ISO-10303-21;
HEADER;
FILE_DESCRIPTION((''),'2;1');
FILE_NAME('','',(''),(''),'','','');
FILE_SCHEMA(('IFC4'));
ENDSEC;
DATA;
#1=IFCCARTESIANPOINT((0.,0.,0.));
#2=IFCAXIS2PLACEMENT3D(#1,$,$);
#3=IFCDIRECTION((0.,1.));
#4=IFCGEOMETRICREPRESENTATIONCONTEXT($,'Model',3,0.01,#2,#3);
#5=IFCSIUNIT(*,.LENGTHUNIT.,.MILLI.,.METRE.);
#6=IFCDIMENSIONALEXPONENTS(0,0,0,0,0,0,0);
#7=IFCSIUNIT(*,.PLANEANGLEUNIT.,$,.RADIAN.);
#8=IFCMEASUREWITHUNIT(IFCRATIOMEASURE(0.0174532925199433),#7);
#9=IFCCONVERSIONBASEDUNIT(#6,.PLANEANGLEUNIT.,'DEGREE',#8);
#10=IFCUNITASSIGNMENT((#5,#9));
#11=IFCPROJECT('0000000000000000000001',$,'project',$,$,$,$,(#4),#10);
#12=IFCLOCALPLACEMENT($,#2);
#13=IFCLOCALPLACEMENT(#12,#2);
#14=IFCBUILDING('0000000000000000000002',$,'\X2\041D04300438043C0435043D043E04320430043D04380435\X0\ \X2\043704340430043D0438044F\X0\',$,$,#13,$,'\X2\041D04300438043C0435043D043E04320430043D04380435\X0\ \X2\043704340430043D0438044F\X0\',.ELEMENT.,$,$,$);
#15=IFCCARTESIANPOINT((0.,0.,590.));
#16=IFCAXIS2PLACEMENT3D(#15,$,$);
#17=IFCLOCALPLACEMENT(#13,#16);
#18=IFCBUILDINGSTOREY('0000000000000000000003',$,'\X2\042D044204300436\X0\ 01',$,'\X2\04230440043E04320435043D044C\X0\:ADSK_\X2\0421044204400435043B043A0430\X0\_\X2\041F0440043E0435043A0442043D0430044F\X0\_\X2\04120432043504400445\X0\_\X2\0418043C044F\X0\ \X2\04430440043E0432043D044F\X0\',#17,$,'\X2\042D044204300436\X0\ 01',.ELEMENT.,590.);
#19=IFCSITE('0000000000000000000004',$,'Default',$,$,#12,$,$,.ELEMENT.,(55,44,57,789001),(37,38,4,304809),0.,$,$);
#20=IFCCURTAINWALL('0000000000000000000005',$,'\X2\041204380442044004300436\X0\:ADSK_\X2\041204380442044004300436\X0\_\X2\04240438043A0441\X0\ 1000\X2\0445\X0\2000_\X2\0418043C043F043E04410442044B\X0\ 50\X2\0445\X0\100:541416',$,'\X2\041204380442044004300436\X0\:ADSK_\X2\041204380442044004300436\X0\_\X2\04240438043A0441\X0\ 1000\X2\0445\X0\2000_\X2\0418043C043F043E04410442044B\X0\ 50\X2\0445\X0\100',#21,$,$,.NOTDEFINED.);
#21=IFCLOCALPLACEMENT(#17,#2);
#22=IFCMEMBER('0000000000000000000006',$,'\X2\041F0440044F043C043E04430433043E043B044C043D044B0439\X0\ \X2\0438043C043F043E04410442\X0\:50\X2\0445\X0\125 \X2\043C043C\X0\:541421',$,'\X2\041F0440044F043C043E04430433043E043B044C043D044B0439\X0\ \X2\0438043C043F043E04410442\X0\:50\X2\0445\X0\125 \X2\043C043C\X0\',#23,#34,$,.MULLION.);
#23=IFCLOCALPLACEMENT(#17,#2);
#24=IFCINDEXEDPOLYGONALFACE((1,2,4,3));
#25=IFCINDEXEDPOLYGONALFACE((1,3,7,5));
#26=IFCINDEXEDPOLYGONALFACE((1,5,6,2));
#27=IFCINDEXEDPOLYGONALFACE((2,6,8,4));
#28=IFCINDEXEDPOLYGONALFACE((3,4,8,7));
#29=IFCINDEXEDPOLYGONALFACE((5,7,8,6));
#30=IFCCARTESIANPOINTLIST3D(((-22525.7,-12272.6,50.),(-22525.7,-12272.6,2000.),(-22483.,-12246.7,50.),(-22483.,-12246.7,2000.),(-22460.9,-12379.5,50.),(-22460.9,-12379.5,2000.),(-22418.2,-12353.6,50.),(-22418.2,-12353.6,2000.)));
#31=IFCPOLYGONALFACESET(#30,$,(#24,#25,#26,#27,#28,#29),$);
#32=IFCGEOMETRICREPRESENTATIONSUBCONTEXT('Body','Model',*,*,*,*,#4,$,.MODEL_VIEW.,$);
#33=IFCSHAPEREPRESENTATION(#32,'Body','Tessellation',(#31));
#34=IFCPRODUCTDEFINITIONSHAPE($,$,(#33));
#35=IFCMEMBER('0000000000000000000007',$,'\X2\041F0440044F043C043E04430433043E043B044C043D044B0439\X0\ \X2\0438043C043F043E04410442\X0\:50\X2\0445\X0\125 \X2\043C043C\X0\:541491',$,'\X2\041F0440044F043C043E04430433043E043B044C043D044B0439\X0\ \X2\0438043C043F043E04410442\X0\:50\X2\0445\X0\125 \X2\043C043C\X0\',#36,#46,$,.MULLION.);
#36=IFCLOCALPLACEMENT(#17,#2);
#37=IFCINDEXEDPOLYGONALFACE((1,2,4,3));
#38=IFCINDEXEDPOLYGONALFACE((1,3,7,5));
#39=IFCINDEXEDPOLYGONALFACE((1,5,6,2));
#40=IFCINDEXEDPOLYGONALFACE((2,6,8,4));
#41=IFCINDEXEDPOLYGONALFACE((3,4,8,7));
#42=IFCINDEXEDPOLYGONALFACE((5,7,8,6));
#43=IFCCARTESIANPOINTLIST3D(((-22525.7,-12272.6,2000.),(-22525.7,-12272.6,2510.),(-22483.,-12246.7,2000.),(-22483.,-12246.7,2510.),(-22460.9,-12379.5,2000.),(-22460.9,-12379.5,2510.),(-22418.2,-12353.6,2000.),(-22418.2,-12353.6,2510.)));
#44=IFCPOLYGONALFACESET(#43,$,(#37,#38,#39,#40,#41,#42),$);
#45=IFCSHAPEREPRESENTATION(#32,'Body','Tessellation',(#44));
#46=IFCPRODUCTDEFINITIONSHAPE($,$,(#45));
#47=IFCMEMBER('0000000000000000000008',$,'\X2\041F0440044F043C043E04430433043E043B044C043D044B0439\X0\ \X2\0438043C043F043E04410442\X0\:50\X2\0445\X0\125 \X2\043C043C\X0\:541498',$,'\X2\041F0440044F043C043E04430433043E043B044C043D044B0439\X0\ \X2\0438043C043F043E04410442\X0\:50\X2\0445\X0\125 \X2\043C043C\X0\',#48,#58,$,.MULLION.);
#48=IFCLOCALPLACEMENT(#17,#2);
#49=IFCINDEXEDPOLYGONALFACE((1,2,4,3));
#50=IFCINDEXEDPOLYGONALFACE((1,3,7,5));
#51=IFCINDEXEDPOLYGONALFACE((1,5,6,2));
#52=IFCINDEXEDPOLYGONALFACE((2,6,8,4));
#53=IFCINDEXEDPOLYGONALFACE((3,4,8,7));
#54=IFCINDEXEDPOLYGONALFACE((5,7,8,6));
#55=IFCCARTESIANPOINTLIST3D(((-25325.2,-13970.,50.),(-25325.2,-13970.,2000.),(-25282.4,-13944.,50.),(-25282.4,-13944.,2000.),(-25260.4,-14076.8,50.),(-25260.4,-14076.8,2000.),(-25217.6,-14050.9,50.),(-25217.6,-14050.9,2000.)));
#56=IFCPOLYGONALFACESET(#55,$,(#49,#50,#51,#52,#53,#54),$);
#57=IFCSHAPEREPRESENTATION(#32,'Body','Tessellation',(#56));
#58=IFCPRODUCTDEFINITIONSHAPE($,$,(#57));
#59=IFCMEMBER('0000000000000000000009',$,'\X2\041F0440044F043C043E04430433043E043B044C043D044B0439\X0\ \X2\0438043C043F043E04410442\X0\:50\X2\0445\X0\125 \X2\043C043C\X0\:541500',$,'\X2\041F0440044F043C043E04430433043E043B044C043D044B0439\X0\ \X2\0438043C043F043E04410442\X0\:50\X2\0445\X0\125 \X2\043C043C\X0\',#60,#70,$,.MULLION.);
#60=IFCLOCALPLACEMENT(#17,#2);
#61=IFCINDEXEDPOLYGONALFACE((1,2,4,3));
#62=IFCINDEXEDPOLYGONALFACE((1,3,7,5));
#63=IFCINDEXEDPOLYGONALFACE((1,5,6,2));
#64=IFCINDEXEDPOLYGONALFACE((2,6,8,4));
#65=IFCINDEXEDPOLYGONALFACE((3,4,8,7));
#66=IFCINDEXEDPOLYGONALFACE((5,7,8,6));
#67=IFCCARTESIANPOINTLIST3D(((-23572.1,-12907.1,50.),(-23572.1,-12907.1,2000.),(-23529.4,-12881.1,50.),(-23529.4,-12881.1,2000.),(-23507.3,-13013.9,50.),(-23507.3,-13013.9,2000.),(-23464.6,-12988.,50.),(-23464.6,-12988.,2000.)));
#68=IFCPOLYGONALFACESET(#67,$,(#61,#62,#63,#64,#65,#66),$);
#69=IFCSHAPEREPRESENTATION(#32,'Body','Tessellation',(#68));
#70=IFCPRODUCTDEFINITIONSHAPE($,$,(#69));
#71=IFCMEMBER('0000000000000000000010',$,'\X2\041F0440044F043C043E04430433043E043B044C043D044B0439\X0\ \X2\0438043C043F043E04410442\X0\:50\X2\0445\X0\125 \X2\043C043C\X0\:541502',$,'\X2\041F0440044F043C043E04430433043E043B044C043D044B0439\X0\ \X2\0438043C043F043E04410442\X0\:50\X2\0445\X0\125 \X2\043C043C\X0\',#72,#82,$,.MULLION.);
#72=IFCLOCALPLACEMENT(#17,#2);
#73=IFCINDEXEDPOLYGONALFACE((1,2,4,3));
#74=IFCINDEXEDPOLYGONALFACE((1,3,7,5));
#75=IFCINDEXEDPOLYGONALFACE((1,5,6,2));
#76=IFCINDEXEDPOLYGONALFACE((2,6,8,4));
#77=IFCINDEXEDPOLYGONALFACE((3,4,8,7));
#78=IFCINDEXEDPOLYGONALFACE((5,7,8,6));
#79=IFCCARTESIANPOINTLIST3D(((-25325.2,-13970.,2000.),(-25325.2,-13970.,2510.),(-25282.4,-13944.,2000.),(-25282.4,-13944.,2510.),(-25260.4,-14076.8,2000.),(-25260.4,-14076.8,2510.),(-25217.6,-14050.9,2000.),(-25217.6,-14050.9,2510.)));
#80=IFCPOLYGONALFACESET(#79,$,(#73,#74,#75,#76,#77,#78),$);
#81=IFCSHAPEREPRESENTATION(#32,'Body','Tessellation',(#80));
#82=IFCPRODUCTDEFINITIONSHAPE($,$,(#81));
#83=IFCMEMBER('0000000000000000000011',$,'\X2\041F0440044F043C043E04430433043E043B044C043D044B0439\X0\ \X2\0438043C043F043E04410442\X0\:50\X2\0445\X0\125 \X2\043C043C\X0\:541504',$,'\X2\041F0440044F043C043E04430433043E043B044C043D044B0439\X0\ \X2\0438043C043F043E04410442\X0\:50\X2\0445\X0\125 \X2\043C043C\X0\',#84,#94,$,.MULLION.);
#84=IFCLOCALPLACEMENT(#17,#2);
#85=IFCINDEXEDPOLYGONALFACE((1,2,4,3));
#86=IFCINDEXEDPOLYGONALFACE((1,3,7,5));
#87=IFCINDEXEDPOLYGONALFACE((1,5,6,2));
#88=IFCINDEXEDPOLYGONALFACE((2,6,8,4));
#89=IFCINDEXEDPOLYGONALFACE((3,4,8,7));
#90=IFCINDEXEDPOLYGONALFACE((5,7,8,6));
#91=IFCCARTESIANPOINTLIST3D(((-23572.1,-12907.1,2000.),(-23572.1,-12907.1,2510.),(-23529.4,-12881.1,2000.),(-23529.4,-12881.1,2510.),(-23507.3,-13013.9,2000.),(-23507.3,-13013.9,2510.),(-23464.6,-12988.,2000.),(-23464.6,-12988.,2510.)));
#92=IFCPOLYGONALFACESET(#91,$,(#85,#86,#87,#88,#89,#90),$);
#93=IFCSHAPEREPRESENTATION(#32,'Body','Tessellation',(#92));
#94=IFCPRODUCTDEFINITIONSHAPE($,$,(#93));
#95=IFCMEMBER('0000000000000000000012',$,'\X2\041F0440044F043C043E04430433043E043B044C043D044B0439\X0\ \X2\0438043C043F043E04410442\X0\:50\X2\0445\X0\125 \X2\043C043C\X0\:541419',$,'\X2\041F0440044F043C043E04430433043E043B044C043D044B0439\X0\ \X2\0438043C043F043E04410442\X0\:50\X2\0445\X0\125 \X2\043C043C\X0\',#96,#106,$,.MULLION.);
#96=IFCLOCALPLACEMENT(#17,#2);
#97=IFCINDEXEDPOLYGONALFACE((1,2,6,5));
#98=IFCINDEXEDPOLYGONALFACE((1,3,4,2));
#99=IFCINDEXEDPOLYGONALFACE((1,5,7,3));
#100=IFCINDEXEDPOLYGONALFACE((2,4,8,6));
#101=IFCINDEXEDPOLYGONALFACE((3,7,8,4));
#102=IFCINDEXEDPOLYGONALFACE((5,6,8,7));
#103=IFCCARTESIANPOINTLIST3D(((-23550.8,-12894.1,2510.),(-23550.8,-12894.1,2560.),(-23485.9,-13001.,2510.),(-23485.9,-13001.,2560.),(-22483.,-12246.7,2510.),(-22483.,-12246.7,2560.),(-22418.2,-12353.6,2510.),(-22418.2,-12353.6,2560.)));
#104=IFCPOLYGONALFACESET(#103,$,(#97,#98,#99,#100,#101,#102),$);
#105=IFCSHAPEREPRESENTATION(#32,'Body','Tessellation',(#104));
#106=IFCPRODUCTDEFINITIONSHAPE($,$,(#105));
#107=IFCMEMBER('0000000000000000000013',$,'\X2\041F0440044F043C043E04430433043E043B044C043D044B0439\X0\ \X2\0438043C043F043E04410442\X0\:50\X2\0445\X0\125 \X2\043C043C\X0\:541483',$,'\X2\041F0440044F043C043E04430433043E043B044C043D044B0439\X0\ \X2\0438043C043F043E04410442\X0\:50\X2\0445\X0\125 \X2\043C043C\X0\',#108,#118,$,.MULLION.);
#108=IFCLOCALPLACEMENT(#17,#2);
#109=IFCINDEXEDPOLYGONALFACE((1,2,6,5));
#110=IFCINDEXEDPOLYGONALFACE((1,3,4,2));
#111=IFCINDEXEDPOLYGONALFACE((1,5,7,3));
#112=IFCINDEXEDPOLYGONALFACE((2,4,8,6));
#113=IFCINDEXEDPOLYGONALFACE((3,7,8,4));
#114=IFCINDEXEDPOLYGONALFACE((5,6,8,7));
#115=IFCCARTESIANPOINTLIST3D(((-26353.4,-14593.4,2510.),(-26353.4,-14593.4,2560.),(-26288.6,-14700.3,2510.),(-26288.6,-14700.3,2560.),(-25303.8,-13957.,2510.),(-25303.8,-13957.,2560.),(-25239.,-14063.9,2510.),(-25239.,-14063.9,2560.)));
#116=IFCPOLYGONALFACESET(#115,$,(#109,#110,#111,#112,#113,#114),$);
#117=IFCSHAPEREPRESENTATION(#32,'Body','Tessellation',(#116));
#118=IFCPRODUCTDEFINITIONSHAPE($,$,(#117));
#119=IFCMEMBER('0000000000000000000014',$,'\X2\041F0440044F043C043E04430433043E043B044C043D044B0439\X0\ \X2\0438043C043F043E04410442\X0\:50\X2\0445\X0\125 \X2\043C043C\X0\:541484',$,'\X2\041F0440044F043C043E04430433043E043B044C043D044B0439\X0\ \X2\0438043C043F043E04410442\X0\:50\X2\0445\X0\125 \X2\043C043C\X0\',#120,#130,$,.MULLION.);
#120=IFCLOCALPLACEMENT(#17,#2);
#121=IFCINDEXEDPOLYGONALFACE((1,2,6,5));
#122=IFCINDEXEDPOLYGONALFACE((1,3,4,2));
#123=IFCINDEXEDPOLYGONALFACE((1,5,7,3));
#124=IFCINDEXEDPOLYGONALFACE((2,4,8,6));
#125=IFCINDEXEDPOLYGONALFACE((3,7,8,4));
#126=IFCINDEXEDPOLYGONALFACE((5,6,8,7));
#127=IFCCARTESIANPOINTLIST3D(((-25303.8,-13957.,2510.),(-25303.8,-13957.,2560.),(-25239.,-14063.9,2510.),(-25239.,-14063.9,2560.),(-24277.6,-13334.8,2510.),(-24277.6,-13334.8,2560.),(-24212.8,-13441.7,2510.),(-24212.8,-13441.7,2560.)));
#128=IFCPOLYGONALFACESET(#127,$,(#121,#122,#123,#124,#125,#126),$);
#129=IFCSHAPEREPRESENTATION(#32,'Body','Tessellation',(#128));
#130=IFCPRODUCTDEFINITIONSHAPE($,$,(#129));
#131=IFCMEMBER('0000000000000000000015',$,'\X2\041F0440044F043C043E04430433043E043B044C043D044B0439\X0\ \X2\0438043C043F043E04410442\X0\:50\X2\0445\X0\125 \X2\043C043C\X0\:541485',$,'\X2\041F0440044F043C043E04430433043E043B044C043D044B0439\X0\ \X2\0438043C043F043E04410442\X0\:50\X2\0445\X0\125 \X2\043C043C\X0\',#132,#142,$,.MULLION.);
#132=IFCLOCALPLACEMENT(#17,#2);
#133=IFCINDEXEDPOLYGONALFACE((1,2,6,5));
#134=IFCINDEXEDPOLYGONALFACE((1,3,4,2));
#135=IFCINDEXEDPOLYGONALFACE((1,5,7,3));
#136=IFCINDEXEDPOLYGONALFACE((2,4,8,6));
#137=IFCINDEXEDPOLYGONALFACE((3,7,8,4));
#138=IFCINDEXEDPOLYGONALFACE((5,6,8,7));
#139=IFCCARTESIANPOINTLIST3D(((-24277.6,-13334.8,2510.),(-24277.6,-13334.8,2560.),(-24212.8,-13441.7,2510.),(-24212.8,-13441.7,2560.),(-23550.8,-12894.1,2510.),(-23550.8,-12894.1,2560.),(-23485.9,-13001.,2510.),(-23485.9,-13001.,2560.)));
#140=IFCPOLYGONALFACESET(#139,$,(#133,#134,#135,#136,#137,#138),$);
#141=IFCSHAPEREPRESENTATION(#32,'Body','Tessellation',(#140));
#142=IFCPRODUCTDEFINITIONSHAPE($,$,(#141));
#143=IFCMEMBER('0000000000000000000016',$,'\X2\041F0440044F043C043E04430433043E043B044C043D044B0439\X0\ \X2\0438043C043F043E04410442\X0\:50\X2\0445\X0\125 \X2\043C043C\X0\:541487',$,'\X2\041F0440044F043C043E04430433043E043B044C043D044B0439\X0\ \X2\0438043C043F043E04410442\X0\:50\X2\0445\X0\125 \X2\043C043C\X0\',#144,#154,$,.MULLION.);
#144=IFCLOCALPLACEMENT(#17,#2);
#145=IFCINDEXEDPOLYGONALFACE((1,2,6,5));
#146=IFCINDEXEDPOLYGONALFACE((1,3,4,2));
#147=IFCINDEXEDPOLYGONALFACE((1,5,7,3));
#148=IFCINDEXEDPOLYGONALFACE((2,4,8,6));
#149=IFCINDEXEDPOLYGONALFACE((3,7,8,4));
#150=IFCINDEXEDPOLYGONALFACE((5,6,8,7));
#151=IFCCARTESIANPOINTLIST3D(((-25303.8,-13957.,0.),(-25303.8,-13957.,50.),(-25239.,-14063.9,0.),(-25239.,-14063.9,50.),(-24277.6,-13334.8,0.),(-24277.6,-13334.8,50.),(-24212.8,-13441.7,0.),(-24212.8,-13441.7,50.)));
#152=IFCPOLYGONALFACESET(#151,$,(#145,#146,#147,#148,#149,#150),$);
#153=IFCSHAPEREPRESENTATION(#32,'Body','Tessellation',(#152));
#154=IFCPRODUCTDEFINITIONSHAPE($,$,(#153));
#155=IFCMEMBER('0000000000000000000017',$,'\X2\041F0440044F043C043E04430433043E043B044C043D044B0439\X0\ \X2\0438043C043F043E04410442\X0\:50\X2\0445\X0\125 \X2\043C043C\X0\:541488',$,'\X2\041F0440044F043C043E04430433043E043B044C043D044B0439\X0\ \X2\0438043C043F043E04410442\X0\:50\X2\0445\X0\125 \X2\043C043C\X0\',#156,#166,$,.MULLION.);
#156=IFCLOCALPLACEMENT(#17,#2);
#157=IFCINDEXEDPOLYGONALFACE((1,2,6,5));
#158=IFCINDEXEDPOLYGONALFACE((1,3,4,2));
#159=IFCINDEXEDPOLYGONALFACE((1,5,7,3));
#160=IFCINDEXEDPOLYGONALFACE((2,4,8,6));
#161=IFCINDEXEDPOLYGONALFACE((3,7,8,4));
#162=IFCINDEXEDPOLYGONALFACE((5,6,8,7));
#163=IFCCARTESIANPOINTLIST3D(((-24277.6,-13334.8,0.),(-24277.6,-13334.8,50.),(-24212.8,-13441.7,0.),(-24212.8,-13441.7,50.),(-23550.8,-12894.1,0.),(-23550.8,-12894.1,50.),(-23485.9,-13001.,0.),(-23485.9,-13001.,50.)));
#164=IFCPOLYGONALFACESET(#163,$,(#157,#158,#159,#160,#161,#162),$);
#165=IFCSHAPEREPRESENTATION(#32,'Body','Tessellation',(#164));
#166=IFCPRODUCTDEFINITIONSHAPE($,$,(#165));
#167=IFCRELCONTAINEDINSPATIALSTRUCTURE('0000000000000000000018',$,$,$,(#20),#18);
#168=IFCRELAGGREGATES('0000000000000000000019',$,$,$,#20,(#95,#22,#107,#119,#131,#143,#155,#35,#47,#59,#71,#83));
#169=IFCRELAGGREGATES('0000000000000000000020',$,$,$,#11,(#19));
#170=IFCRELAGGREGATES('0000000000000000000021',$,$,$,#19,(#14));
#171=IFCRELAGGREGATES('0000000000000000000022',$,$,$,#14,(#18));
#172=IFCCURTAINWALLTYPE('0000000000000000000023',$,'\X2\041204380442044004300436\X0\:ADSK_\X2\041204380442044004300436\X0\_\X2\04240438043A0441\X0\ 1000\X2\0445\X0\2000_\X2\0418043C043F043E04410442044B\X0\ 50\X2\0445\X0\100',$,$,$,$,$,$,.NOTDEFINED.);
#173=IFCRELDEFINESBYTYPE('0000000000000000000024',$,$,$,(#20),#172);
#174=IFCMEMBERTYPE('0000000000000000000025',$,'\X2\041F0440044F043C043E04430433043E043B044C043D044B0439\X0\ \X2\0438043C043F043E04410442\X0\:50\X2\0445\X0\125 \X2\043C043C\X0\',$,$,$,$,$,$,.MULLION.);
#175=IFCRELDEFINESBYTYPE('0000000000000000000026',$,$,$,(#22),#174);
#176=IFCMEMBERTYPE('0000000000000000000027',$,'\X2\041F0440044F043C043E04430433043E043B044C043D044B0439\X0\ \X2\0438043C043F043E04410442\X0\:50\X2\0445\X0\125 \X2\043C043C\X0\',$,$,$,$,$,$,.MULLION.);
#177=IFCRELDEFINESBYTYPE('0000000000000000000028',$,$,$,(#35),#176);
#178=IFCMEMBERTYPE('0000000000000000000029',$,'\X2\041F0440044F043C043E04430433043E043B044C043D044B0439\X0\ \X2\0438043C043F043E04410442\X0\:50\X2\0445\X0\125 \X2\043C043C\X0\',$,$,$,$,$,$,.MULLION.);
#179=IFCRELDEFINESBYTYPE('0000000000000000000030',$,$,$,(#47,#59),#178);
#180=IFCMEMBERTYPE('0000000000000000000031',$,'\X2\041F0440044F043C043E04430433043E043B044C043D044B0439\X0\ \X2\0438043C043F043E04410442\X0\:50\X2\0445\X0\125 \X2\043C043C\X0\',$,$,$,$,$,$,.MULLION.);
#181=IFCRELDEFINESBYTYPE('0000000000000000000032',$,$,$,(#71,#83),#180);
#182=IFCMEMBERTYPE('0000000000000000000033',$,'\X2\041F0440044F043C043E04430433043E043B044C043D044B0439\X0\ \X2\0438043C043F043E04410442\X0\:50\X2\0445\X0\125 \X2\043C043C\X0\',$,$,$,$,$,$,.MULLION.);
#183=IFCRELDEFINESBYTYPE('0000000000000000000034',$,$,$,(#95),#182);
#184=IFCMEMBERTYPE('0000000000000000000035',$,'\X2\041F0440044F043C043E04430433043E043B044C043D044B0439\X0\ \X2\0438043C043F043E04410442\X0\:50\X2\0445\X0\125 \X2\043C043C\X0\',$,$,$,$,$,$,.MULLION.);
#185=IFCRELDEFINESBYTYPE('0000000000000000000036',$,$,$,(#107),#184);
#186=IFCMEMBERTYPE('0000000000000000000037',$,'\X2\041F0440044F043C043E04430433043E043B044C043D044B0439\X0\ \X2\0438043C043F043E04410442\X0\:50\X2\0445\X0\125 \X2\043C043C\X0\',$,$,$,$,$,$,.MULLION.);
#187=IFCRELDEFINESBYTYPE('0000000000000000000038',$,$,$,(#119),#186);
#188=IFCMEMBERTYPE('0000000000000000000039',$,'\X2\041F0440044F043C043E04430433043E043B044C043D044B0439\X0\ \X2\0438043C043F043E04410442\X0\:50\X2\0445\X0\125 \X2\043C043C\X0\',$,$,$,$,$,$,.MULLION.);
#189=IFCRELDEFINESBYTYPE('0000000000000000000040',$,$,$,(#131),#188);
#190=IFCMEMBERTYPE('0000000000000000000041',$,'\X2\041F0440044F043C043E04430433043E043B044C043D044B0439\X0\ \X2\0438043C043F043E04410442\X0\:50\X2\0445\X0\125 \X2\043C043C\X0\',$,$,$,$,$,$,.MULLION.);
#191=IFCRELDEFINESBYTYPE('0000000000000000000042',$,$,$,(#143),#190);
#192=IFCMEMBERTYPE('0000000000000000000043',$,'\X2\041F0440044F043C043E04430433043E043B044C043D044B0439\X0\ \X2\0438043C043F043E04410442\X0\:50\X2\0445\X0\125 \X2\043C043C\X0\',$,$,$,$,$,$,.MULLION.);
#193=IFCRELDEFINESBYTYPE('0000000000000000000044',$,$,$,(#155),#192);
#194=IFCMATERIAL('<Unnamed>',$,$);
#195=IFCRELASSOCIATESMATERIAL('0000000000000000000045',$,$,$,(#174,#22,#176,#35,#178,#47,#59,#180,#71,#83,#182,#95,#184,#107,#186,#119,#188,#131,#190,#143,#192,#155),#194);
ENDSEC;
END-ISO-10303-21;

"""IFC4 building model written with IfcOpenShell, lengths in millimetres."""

from ifc_helpers import new_model, entity, si_unit, converted_unit, direction, frame, origin, place, context, subcontext, project, spatial, indexed_curve, outline, extrude, source, transform, mapped, material, type_object, type_shapes, element, aggregate, save


model = new_model("IFC4")

# Units and contexts
model_context = context("Model", 3, precision=0.01, world=origin(), true_north=direction((0.0, 1.0)))
body_context = subcontext(model_context, "Body", "Model", "MODEL_VIEW")
ifc_project = project(units=[si_unit("LENGTHUNIT", "METRE", prefix="MILLI"), converted_unit("PLANEANGLEUNIT", "DEGREE", entity("IfcRatioMeasure", 0.0174532925199433), si_unit("PLANEANGLEUNIT", "RADIAN"), dimensions=[0, 0, 0, 0, 0, 0, 0])], contexts=[model_context])

# Site, building, storey
site_placement = place(None, origin())
site = spatial("IfcSite", under=ifc_project, at=site_placement, Name="Default", CompositionType="ELEMENT", RefLatitude=(55, 44, 57, 789001), RefLongitude=(37, 38, 4, 304809), RefElevation=0.0)
building_placement = place(site_placement, origin())
building = spatial("IfcBuilding", under=site, at=building_placement, Name="Наименование здания", LongName="Наименование здания", CompositionType="ELEMENT")
storey_placement = place(building_placement, frame((0.0, 0.0, 590.0)))
storey = spatial("IfcBuildingStorey", under=building, at=storey_placement, Name="Этаж 01", ObjectType="Уровень:ADSK_Стрелка_Проектная_Вверх_Имя уровня", LongName="Этаж 01", CompositionType="ELEMENT", Elevation=590.0)

# Curtain wall, members
curtain_wall_type = type_object("IfcCurtainWallType", Name="Витраж:ADSK_Витраж_Фикс 1000х2000_Импосты 50х100", PredefinedType="NOTDEFINED")
curtain_wall_placement = place(storey_placement, frame((0.0, 0.0, -590.0)))
curtain_wall = element("IfcCurtainWall", 1, at=curtain_wall_placement, inside=storey, type_object=curtain_wall_type, Name="Витраж:ADSK_Витраж_Фикс 1000х2000_Импосты 50х100:541416", ObjectType="Витраж:ADSK_Витраж_Фикс 1000х2000_Импосты 50х100", PredefinedType="NOTDEFINED")
ifc_material_1 = material(Name="<Unnamed>")
member_type_1 = type_object("IfcMemberType", Name="Прямоугольный импост:50х125 мм", PredefinedType="MULLION", material=ifc_material_1)
shared_shape_1 = source(origin(), body_context, "Body", "SweptSolid", [
    extrude(outline(indexed_curve([(-62.5, -25.0), (62.5, -25.0), (62.5, 25.0), (-62.5, 25.0), (-62.5, -25.0)], self_intersect=False)), frame((-25.0, 0.0, -1950.0), z_axis=(0.0, 0.0, 1.0), x_axis=(0.0, -1.0, 0.0)), (0.0, 0.0, 1.0), 1950.0),
])
type_shapes(member_type_1, [shared_shape_1])
member_1_placement = place(storey_placement, frame((-22450.6, -12300.1, 50.0), z_axis=(0.0, 0.0, -1.0), x_axis=(0.855102, 0.51846, 0.0)))
member_1 = element("IfcMember", 2, at=member_1_placement, type_object=member_type_1, material=ifc_material_1, Name="Прямоугольный импост:50х125 мм:541421", ObjectType="Прямоугольный импост:50х125 мм", PredefinedType="MULLION", context=body_context, shape_type="MappedRepresentation", body=[
    mapped(shared_shape_1, transform((0.0, 0.0, 0.0), scale=1.0)),
])
member_type_2 = type_object("IfcMemberType", Name="Прямоугольный импост:50х125 мм", PredefinedType="MULLION", material=ifc_material_1)
shared_shape_2 = source(origin(), body_context, "Body", "SweptSolid", [
    extrude(outline(indexed_curve([(-62.5, -25.0), (62.5, -25.0), (62.5, 25.0), (-62.5, 25.0), (-62.5, -25.0)], self_intersect=False)), frame((-25.0, 0.0, -510.0), z_axis=(0.0, 0.0, 1.0), x_axis=(0.0, -1.0, 0.0)), (0.0, 0.0, 1.0), 510.0),
])
type_shapes(member_type_2, [shared_shape_2])
member_2_placement = place(storey_placement, frame((-22450.6, -12300.1, 2000.0), z_axis=(0.0, 0.0, -1.0), x_axis=(0.855102, 0.51846, 0.0)))
member_2 = element("IfcMember", 3, at=member_2_placement, type_object=member_type_2, material=ifc_material_1, Name="Прямоугольный импост:50х125 мм:541491", ObjectType="Прямоугольный импост:50х125 мм", PredefinedType="MULLION", context=body_context, shape_type="MappedRepresentation", body=[
    mapped(shared_shape_2, transform((0.0, 0.0, 0.0), scale=1.0)),
])
member_type_3 = type_object("IfcMemberType", Name="Прямоугольный импост:50х125 мм", PredefinedType="MULLION", material=ifc_material_1)
shared_shape_3 = source(origin(), body_context, "Body", "SweptSolid", [
    extrude(outline(indexed_curve([(-62.5, -25.0), (62.5, -25.0), (62.5, 25.0), (-62.5, 25.0), (-62.5, -25.0)], self_intersect=False)), frame((0.0, 0.0, -1950.0), z_axis=(0.0, 0.0, 1.0), x_axis=(0.0, -1.0, 0.0)), (0.0, 0.0, 1.0), 1950.0),
])
type_shapes(member_type_3, [shared_shape_3])
member_3_placement = place(storey_placement, frame((-25271.4, -14010.4, 50.0), z_axis=(0.0, 0.0, -1.0), x_axis=(0.855102, 0.51846, 0.0)))
member_3 = element("IfcMember", 4, at=member_3_placement, type_object=member_type_3, material=ifc_material_1, Name="Прямоугольный импост:50х125 мм:541498", ObjectType="Прямоугольный импост:50х125 мм", PredefinedType="MULLION", context=body_context, shape_type="MappedRepresentation", body=[
    mapped(shared_shape_3, transform((0.0, 0.0, 0.0), scale=1.0)),
])
member_4_placement = place(storey_placement, frame((-23518.4, -12947.5, 50.0), z_axis=(0.0, 0.0, -1.0), x_axis=(0.855102, 0.51846, 0.0)))
member_4 = element("IfcMember", 5, at=member_4_placement, type_object=member_type_3, material=ifc_material_1, Name="Прямоугольный импост:50х125 мм:541500", ObjectType="Прямоугольный импост:50х125 мм", PredefinedType="MULLION", context=body_context, shape_type="MappedRepresentation", body=[
    mapped(shared_shape_3, transform((0.0, 0.0, 0.0), scale=1.0)),
])
member_type_4 = type_object("IfcMemberType", Name="Прямоугольный импост:50х125 мм", PredefinedType="MULLION", material=ifc_material_1)
shared_shape_4 = source(origin(), body_context, "Body", "SweptSolid", [
    extrude(outline(indexed_curve([(-62.5, -25.0), (62.5, -25.0), (62.5, 25.0), (-62.5, 25.0), (-62.5, -25.0)], self_intersect=False)), frame((0.0, 0.0, -510.0), z_axis=(0.0, 0.0, 1.0), x_axis=(0.0, -1.0, 0.0)), (0.0, 0.0, 1.0), 510.0),
])
type_shapes(member_type_4, [shared_shape_4])
member_5_placement = place(storey_placement, frame((-25271.4, -14010.4, 2000.0), z_axis=(0.0, 0.0, -1.0), x_axis=(0.855102, 0.51846, 0.0)))
member_5 = element("IfcMember", 6, at=member_5_placement, type_object=member_type_4, material=ifc_material_1, Name="Прямоугольный импост:50х125 мм:541502", ObjectType="Прямоугольный импост:50х125 мм", PredefinedType="MULLION", context=body_context, shape_type="MappedRepresentation", body=[
    mapped(shared_shape_4, transform((0.0, 0.0, 0.0), scale=1.0)),
])
member_6_placement = place(storey_placement, frame((-23518.4, -12947.5, 2000.0), z_axis=(0.0, 0.0, -1.0), x_axis=(0.855102, 0.51846, 0.0)))
member_6 = element("IfcMember", 7, at=member_6_placement, type_object=member_type_4, material=ifc_material_1, Name="Прямоугольный импост:50х125 мм:541504", ObjectType="Прямоугольный импост:50х125 мм", PredefinedType="MULLION", context=body_context, shape_type="MappedRepresentation", body=[
    mapped(shared_shape_4, transform((0.0, 0.0, 0.0), scale=1.0)),
])
member_type_5 = type_object("IfcMemberType", Name="Прямоугольный импост:50х125 мм", PredefinedType="MULLION", material=ifc_material_1)
shared_shape_5 = source(origin(), body_context, "Body", "SweptSolid", [
    extrude(outline(indexed_curve([(-62.5, -25.0), (62.5, -25.0), (62.5, 25.0), (-62.5, 25.0), (-62.5, -25.0)], self_intersect=False)), frame((-25.0, 0.0, -1248.7), z_axis=(0.0, 0.0, 1.0), x_axis=(0.0, -1.0, 0.0)), (0.0, 0.0, 1.0), 1248.7),
])
type_shapes(member_type_5, [shared_shape_5])
member_7_placement = place(storey_placement, frame((-22450.6, -12300.1, 2560.0), z_axis=(0.855102, 0.51846, 0.0), x_axis=(0.0, 0.0, 1.0)))
member_7 = element("IfcMember", 8, at=member_7_placement, type_object=member_type_5, material=ifc_material_1, Name="Прямоугольный импост:50х125 мм:541419", ObjectType="Прямоугольный импост:50х125 мм", PredefinedType="MULLION", context=body_context, shape_type="MappedRepresentation", body=[
    mapped(shared_shape_5, transform((0.0, 0.0, 0.0), scale=1.0)),
])
member_type_6 = type_object("IfcMemberType", Name="Прямоугольный импост:50х125 мм", PredefinedType="MULLION", material=ifc_material_1)
shared_shape_6 = source(origin(), body_context, "Body", "SweptSolid", [
    extrude(outline(indexed_curve([(-62.5, -25.0), (62.5, -25.0), (62.5, 25.0), (-62.5, 25.0), (-62.5, -25.0)], self_intersect=False)), frame((-25.0, 0.0, -1227.5), z_axis=(0.0, 0.0, 1.0), x_axis=(0.0, -1.0, 0.0)), (0.0, 0.0, 1.0), 1227.5),
])
type_shapes(member_type_6, [shared_shape_6])
member_8_placement = place(storey_placement, frame((-25271.4, -14010.4, 2560.0), z_axis=(0.855102, 0.51846, 0.0), x_axis=(0.0, 0.0, 1.0)))
member_8 = element("IfcMember", 9, at=member_8_placement, type_object=member_type_6, material=ifc_material_1, Name="Прямоугольный импост:50х125 мм:541483", ObjectType="Прямоугольный импост:50х125 мм", PredefinedType="MULLION", context=body_context, shape_type="MappedRepresentation", body=[
    mapped(shared_shape_6, transform((0.0, 0.0, 0.0), scale=1.0)),
])
member_type_7 = type_object("IfcMemberType", Name="Прямоугольный импост:50х125 мм", PredefinedType="MULLION", material=ifc_material_1)
shared_shape_7 = source(origin(), body_context, "Body", "SweptSolid", [
    extrude(outline(indexed_curve([(-62.5, -25.0), (62.5, -25.0), (62.5, 25.0), (-62.5, 25.0), (-62.5, -25.0)], self_intersect=False)), frame((-25.0, 0.0, -1200.1), z_axis=(0.0, 0.0, 1.0), x_axis=(0.0, -1.0, 0.0)), (0.0, 0.0, 1.0), 1200.1),
])
type_shapes(member_type_7, [shared_shape_7])
member_9_placement = place(storey_placement, frame((-24245.2, -13388.2, 2560.0), z_axis=(0.855102, 0.51846, 0.0), x_axis=(0.0, 0.0, 1.0)))
member_9 = element("IfcMember", 10, at=member_9_placement, type_object=member_type_7, material=ifc_material_1, Name="Прямоугольный импост:50х125 мм:541484", ObjectType="Прямоугольный импост:50х125 мм", PredefinedType="MULLION", context=body_context, shape_type="MappedRepresentation", body=[
    mapped(shared_shape_7, transform((0.0, 0.0, 0.0), scale=1.0)),
])
member_type_8 = type_object("IfcMemberType", Name="Прямоугольный импост:50х125 мм", PredefinedType="MULLION", material=ifc_material_1)
shared_shape_8 = source(origin(), body_context, "Body", "SweptSolid", [
    extrude(outline(indexed_curve([(-62.5, -25.0), (62.5, -25.0), (62.5, 25.0), (-62.5, 25.0), (-62.5, -25.0)], self_intersect=False)), frame((-25.0, 0.0, -850.0), z_axis=(0.0, 0.0, 1.0), x_axis=(0.0, -1.0, 0.0)), (0.0, 0.0, 1.0), 850.0),
])
type_shapes(member_type_8, [shared_shape_8])
member_10_placement = place(storey_placement, frame((-23518.4, -12947.5, 2560.0), z_axis=(0.855102, 0.51846, 0.0), x_axis=(0.0, 0.0, 1.0)))
member_10 = element("IfcMember", 11, at=member_10_placement, type_object=member_type_8, material=ifc_material_1, Name="Прямоугольный импост:50х125 мм:541485", ObjectType="Прямоугольный импост:50х125 мм", PredefinedType="MULLION", context=body_context, shape_type="MappedRepresentation", body=[
    mapped(shared_shape_8, transform((0.0, 0.0, 0.0), scale=1.0)),
])
member_type_9 = type_object("IfcMemberType", Name="Прямоугольный импост:50х125 мм", PredefinedType="MULLION", material=ifc_material_1)
shared_shape_9 = source(origin(), body_context, "Body", "SweptSolid", [
    extrude(outline(indexed_curve([(-62.5, -25.0), (62.5, -25.0), (62.5, 25.0), (-62.5, 25.0), (-62.5, -25.0)], self_intersect=False)), frame((-25.0, 0.0, -1200.1), z_axis=(0.0, 0.0, 1.0), x_axis=(0.0, -1.0, 0.0)), (0.0, 0.0, 1.0), 1200.1),
])
type_shapes(member_type_9, [shared_shape_9])
member_11_placement = place(storey_placement, frame((-25271.4, -14010.4, 0.0), z_axis=(-0.855102, -0.51846, 0.0), x_axis=(0.0, 0.0, -1.0)))
member_11 = element("IfcMember", 12, at=member_11_placement, type_object=member_type_9, material=ifc_material_1, Name="Прямоугольный импост:50х125 мм:541487", ObjectType="Прямоугольный импост:50х125 мм", PredefinedType="MULLION", context=body_context, shape_type="MappedRepresentation", body=[
    mapped(shared_shape_9, transform((0.0, 0.0, 0.0), scale=1.0)),
])
member_type_10 = type_object("IfcMemberType", Name="Прямоугольный импост:50х125 мм", PredefinedType="MULLION", material=ifc_material_1)
shared_shape_10 = source(origin(), body_context, "Body", "SweptSolid", [
    extrude(outline(indexed_curve([(-62.5, -25.0), (62.5, -25.0), (62.5, 25.0), (-62.5, 25.0), (-62.5, -25.0)], self_intersect=False)), frame((-25.0, 0.0, -850.0), z_axis=(0.0, 0.0, 1.0), x_axis=(0.0, -1.0, 0.0)), (0.0, 0.0, 1.0), 850.0),
])
type_shapes(member_type_10, [shared_shape_10])
member_12_placement = place(storey_placement, frame((-24245.2, -13388.2, 0.0), z_axis=(-0.855102, -0.51846, 0.0), x_axis=(0.0, 0.0, -1.0)))
member_12 = element("IfcMember", 13, at=member_12_placement, type_object=member_type_10, material=ifc_material_1, Name="Прямоугольный импост:50х125 мм:541488", ObjectType="Прямоугольный импост:50х125 мм", PredefinedType="MULLION", context=body_context, shape_type="MappedRepresentation", body=[
    mapped(shared_shape_10, transform((0.0, 0.0, 0.0), scale=1.0)),
])

aggregate(curtain_wall, [member_7, member_1, member_8, member_9, member_10, member_11, member_12, member_2, member_3, member_4, member_5, member_6])

save(model, "model.ifc")
